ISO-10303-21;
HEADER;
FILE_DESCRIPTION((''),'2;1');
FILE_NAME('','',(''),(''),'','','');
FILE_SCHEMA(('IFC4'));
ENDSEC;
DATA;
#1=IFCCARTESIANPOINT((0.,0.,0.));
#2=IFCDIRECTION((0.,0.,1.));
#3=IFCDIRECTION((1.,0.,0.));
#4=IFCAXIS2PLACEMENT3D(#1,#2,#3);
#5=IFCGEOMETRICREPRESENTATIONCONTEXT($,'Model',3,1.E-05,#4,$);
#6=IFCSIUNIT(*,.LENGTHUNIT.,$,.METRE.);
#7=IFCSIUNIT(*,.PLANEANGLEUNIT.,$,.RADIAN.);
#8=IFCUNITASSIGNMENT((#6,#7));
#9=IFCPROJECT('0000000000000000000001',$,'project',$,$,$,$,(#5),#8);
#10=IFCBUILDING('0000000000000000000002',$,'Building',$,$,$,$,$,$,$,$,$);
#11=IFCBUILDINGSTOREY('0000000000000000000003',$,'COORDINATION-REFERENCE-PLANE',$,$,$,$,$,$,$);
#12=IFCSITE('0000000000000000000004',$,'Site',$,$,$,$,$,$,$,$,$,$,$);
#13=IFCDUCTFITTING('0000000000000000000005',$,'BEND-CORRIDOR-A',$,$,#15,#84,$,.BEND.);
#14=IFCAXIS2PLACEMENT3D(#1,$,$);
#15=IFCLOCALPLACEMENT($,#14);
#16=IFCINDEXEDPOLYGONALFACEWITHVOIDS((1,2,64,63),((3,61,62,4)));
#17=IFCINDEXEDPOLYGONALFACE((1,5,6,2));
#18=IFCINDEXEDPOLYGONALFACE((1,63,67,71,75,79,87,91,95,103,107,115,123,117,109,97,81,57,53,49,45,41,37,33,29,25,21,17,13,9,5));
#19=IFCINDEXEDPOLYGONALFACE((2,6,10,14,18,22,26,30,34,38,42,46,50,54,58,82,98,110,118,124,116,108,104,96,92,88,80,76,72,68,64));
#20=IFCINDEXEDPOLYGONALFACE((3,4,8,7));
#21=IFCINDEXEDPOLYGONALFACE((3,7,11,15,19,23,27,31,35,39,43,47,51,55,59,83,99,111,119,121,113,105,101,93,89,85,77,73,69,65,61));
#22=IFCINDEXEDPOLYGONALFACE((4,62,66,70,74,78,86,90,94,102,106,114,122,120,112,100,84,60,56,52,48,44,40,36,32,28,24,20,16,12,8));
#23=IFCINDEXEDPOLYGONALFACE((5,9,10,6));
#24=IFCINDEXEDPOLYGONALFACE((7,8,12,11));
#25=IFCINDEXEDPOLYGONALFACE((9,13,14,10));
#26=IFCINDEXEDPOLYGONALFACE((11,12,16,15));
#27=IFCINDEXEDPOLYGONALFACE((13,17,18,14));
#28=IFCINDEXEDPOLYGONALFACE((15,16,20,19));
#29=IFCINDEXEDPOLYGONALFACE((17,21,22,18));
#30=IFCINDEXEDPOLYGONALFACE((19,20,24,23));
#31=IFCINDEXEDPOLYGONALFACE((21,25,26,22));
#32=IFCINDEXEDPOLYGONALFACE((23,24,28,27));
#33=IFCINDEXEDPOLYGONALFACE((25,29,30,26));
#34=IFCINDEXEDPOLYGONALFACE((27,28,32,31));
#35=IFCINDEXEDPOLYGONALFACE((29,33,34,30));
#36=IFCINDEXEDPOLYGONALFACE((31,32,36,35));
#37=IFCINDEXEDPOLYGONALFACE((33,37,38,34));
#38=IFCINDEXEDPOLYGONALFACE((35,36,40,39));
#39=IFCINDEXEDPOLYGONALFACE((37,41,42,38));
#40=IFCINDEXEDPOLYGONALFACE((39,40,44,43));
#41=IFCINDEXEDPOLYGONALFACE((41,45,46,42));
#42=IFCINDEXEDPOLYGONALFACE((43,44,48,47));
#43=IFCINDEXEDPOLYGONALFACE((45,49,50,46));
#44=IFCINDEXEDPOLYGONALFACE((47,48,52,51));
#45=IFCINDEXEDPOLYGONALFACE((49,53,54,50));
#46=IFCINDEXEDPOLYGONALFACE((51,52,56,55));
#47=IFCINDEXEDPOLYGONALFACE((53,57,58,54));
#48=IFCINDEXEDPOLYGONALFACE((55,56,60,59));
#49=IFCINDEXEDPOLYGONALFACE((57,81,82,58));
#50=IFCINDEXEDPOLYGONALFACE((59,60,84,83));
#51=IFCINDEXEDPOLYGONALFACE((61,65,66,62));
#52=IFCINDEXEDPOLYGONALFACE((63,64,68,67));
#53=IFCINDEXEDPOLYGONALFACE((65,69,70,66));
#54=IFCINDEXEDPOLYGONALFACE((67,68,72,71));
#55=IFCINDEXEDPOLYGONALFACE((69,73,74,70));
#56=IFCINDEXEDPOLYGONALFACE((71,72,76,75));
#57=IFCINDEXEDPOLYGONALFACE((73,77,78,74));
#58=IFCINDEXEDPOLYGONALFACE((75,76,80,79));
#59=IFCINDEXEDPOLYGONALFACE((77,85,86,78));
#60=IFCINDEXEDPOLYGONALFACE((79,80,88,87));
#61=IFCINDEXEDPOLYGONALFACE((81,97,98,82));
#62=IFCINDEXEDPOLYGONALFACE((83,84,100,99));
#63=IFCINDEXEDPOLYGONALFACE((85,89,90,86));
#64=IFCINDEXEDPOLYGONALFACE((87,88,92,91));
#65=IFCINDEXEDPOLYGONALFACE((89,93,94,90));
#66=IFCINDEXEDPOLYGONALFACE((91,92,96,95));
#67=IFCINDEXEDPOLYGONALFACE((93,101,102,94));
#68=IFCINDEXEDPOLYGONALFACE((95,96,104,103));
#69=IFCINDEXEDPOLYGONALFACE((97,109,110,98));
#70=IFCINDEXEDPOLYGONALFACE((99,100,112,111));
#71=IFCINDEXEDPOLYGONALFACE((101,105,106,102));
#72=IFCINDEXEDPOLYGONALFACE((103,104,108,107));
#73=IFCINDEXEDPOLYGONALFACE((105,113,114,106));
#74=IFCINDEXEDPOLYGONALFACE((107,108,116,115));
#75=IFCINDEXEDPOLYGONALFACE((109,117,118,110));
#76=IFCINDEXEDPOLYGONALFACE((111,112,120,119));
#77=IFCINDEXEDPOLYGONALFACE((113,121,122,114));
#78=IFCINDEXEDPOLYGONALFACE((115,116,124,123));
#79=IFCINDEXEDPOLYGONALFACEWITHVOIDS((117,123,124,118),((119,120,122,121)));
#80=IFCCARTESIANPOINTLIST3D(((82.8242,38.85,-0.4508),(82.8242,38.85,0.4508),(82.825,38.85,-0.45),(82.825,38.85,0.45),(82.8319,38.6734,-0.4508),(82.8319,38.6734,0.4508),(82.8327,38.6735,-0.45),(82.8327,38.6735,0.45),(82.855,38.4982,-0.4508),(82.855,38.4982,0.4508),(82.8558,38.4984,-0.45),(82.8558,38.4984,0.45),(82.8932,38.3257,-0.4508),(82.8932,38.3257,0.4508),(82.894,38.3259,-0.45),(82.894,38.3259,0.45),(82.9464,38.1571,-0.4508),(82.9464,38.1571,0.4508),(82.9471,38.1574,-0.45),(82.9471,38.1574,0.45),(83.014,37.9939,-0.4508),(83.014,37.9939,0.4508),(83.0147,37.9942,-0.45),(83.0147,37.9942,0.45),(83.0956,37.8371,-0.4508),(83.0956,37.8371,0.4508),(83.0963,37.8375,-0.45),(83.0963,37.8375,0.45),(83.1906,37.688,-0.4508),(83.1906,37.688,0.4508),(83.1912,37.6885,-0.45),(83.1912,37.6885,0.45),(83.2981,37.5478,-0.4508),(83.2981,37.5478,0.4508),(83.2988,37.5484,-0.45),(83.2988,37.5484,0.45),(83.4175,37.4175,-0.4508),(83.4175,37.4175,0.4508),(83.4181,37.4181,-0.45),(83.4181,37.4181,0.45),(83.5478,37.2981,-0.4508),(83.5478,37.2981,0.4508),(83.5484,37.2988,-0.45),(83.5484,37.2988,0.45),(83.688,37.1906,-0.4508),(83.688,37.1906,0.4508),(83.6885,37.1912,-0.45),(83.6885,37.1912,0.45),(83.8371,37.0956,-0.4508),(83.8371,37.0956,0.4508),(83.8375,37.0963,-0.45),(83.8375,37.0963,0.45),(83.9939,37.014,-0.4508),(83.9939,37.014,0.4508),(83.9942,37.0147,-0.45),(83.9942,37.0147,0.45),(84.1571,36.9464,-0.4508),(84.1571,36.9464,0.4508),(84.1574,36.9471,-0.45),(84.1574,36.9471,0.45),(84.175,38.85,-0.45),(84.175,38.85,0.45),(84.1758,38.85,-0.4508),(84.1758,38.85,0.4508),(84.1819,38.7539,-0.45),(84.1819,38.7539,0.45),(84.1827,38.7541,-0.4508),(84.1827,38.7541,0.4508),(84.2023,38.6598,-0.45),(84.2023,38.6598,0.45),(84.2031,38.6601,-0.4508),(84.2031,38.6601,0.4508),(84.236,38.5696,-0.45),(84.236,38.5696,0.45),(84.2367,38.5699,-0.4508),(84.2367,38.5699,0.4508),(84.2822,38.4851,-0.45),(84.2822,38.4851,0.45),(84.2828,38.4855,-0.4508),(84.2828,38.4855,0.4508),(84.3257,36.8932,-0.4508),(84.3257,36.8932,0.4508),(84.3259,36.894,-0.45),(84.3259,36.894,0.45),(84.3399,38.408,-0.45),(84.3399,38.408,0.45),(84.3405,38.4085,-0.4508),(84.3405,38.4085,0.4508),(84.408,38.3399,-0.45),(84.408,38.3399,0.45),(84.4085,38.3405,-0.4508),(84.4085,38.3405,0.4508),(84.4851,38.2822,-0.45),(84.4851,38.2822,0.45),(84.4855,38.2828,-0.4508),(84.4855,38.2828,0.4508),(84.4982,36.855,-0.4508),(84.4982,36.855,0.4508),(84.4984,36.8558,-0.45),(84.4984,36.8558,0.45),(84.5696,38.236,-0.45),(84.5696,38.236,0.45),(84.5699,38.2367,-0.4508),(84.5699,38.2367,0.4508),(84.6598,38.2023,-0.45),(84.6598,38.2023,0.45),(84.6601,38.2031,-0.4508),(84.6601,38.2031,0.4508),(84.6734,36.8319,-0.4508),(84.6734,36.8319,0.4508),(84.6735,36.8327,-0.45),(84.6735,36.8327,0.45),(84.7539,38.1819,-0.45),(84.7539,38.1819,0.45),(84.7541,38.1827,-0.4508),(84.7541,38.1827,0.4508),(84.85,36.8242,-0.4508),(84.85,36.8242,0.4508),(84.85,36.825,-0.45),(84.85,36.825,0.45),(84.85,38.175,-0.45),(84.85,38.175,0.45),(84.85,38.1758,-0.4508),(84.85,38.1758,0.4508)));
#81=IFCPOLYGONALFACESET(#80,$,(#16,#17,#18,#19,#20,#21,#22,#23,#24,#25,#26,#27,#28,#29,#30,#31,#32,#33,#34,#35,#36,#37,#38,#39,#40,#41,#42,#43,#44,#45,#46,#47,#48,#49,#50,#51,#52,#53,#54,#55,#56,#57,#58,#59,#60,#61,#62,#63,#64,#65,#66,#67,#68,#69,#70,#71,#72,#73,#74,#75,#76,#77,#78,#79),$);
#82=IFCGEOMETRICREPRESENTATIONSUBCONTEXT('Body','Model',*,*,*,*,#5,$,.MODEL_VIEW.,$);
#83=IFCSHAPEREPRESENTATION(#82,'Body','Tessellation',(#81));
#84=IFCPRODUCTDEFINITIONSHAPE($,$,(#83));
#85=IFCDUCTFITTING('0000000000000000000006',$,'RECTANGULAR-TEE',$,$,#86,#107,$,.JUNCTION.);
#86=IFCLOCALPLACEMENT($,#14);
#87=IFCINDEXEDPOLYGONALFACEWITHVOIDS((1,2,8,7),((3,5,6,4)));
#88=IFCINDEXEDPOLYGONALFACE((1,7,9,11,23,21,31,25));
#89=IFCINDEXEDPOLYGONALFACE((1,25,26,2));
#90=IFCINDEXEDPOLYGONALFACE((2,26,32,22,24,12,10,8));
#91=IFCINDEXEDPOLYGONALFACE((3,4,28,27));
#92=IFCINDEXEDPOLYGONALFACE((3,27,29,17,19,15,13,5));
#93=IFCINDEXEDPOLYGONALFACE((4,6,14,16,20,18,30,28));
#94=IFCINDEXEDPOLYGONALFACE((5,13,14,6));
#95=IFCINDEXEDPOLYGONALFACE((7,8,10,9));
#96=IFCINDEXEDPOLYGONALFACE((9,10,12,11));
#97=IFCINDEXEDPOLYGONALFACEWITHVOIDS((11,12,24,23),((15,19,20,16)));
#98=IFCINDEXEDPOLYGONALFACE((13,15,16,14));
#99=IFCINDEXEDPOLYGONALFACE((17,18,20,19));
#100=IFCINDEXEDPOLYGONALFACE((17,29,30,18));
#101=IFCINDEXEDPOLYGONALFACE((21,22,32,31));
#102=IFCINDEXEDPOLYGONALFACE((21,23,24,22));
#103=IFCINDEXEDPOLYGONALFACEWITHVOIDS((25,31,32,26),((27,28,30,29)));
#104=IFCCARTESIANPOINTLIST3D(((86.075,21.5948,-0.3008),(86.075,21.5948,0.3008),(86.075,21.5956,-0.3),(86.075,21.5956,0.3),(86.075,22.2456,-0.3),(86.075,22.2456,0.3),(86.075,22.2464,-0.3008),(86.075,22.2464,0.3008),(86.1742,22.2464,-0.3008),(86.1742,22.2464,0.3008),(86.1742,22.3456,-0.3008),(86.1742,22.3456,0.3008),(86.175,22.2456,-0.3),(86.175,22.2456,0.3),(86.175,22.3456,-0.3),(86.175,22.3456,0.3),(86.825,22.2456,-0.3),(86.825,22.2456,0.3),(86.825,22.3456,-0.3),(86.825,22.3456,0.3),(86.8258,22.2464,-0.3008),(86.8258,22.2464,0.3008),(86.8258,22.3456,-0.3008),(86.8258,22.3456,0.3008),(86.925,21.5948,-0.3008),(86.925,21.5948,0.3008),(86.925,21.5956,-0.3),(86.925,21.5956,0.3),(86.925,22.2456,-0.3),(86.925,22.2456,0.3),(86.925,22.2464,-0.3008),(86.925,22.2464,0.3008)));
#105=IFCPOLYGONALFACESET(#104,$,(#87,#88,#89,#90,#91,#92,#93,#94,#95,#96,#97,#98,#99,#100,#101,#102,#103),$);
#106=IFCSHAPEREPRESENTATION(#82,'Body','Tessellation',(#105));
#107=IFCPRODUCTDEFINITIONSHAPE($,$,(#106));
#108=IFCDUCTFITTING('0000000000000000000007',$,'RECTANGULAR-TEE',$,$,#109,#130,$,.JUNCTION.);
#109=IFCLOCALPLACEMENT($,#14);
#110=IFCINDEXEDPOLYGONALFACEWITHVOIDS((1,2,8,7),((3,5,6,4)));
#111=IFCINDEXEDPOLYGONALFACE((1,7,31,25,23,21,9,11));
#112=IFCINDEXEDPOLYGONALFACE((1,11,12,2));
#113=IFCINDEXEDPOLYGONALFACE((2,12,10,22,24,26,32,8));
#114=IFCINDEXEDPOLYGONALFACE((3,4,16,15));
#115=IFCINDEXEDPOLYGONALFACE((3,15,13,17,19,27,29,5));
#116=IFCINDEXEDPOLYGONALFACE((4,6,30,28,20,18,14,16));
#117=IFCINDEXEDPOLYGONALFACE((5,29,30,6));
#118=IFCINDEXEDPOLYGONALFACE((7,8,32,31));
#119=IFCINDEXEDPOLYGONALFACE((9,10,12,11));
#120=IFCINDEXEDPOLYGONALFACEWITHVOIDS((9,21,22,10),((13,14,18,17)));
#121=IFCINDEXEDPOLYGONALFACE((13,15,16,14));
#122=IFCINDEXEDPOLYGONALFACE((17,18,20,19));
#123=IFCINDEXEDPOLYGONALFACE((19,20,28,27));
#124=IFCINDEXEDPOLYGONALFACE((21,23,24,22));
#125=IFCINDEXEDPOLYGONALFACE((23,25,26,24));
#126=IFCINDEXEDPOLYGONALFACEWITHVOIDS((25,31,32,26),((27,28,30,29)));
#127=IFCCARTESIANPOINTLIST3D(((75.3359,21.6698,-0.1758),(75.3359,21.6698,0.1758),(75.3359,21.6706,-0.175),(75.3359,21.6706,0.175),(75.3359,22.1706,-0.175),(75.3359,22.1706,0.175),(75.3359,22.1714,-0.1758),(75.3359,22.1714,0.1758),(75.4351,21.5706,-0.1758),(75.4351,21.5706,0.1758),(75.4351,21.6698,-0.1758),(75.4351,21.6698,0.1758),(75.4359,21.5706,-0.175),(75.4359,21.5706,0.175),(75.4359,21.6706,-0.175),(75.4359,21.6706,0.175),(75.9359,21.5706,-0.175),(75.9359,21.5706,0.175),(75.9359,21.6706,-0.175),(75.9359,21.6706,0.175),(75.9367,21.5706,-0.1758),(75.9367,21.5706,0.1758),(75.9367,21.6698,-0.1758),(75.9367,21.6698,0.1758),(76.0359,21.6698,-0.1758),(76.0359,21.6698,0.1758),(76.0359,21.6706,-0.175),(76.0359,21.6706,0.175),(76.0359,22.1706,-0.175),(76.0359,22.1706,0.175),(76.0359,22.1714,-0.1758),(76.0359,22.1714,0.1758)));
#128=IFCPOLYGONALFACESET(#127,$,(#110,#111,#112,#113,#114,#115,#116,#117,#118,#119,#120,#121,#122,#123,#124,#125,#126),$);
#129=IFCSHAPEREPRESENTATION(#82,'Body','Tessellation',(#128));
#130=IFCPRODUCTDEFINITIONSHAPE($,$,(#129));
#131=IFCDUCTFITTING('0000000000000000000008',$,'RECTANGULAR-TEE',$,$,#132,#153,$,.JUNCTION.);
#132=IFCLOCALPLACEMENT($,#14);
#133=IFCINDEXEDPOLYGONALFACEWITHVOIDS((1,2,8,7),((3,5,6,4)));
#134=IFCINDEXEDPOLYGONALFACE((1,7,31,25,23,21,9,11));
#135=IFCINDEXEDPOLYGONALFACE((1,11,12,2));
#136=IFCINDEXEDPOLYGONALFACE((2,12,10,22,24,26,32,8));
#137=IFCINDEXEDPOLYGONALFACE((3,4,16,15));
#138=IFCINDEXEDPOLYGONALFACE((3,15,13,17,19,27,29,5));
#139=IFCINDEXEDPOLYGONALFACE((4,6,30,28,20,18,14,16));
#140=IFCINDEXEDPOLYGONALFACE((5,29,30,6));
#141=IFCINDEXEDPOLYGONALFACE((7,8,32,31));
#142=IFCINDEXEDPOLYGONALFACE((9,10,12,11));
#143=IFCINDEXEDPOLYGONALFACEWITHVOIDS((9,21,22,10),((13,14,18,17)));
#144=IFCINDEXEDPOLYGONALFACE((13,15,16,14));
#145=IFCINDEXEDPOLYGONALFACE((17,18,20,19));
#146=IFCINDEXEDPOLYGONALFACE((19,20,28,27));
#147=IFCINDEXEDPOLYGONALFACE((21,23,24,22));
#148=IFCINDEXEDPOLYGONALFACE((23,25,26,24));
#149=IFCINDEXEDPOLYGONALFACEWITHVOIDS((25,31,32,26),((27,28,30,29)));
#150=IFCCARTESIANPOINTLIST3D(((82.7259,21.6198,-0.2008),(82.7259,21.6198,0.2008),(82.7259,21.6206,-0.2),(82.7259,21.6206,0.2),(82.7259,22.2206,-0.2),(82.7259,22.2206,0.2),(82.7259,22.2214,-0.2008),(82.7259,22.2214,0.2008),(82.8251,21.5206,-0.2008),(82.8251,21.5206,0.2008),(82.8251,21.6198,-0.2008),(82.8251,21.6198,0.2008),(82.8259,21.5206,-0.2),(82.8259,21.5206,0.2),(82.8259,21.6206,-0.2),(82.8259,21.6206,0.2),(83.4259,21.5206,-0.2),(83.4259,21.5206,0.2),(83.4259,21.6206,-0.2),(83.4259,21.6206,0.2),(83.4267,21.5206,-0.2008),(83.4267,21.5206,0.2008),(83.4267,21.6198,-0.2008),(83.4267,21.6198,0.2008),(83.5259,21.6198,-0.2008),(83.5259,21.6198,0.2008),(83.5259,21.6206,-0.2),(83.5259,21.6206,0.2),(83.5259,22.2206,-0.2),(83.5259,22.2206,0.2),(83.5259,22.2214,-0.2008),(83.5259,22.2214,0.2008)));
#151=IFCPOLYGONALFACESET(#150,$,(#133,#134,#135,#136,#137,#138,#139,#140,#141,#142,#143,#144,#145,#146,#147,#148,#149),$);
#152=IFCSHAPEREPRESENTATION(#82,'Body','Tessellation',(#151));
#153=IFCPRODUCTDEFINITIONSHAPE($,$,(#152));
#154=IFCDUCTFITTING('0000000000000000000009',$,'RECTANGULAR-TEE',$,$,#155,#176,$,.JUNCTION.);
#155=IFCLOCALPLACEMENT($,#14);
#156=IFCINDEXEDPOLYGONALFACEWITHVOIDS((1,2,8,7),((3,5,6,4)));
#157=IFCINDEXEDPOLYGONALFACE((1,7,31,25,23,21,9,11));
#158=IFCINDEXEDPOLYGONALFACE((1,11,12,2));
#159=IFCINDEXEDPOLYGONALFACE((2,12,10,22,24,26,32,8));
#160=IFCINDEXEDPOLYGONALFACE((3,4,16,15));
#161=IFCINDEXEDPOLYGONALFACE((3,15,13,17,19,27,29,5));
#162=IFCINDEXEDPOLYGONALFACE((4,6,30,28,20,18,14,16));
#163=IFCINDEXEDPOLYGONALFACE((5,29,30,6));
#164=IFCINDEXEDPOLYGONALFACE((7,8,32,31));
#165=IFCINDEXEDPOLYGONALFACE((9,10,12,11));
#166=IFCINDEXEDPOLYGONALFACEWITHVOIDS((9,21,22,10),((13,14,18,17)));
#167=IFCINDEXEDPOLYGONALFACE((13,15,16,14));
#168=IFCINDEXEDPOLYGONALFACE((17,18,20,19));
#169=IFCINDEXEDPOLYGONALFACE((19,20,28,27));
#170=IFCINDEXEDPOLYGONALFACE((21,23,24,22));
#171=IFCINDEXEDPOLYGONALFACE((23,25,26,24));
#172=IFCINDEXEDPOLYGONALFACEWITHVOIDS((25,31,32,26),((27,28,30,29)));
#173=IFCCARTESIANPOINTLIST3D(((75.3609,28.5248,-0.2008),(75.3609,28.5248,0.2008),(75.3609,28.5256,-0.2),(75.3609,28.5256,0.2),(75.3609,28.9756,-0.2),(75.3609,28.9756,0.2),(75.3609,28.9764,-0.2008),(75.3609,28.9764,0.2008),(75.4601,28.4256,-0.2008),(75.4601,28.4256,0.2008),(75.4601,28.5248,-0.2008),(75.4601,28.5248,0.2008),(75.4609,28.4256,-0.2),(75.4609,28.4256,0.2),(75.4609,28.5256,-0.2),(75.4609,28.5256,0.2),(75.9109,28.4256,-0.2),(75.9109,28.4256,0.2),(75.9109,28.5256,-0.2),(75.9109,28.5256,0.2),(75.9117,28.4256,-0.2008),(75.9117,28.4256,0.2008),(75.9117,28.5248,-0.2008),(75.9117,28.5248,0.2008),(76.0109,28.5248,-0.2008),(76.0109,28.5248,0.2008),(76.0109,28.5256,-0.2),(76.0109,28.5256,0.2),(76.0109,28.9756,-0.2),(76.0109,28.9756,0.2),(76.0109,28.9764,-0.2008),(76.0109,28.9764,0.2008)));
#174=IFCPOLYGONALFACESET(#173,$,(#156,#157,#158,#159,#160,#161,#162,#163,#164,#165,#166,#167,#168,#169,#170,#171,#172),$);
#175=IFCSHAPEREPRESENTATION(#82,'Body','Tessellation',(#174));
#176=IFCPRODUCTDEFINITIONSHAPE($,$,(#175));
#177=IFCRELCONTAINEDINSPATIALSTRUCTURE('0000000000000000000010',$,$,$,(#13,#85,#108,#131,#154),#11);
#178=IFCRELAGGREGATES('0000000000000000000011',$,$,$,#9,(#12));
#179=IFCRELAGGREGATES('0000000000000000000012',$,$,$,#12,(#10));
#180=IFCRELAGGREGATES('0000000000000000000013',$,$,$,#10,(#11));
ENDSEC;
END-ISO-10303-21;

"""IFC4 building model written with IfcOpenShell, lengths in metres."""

from ifc_helpers import new_model, entity, si_unit, frame, origin_with_axes, place, context, subcontext, project, spatial, rectangle, extrude, boolean, element, save


model = new_model("IFC4")

# Units and contexts
model_context = context("Model", 3, precision=1e-05, world=origin_with_axes())
body_context = subcontext(model_context, "Body", "Model", "MODEL_VIEW")
ifc_project = project(units=[si_unit("LENGTHUNIT", "METRE"), si_unit("PLANEANGLEUNIT", "RADIAN")], contexts=[model_context])

# Site, building, storey
site = spatial("IfcSite", under=ifc_project, Name="Site")
building = spatial("IfcBuilding", under=site, Name="Building")
storey = spatial("IfcBuildingStorey", under=building, Name="COORDINATION-REFERENCE-PLANE")

# Duct fittings
duct_fitting_1_placement = place(None, frame((84.85, 38.85, 0.0), z_axis=(0.0, 0.0, 1.0), x_axis=(-1.0, 0.0, 0.0)))
cartesian_point_1 = entity("IfcCartesianPoint", [0.0, 0.0, 0.0])
element("IfcDuctFitting", 1, at=duct_fitting_1_placement, inside=storey, Name="BEND-CORRIDOR-A", PredefinedType="BEND", context=body_context, shape_type="SweptSolid", body=[
    entity("IfcRevolvedAreaSolid", entity("IfcRectangleHollowProfileDef", "AREA", None, entity("IfcAxis2Placement2D", entity("IfcCartesianPoint", [1.35, 0.0])), 1.3516, 0.9016, 0.0008), entity("IfcAxis2Placement3D", cartesian_point_1, entity("IfcDirection", [0.0, -1.0, 0.0]), entity("IfcDirection", [1.0, 0.0, 0.0])), entity("IfcAxis1Placement", cartesian_point_1, entity("IfcDirection", [0.0, 1.0, 0.0])), 1.570796),
])
duct_fitting_2_placement = place(None, frame((86.5, 21.9206, 0.0), z_axis=(1.0, 0.0, 0.0), x_axis=(0.0, 1.0, 0.0)))
solid_1 = boolean("UNION", extrude(rectangle(XDim=0.65, YDim=0.6), frame((0.0, 0.0, -0.425), z_axis=(0.0, 0.0, 1.0), x_axis=(1.0, 0.0, 0.0)), (0.0, 0.0, 1.0), 0.85), extrude(rectangle(XDim=0.65, YDim=0.6), frame((0.0, 0.0, 0.0), z_axis=(1.0, 0.0, 0.0), x_axis=(0.0, 0.0, -1.0)), (0.0, 0.0, 1.0), 0.425))
element("IfcDuctFitting", 2, at=duct_fitting_2_placement, inside=storey, Name="RECTANGULAR-TEE", PredefinedType="JUNCTION", context=body_context, shape_type="CSG", body=[
    boolean("DIFFERENCE", boolean("UNION", extrude(rectangle(XDim=0.6516, YDim=0.6016), frame((0.0, 0.0, -0.425), z_axis=(0.0, 0.0, 1.0), x_axis=(1.0, 0.0, 0.0)), (0.0, 0.0, 1.0), 0.85), extrude(rectangle(XDim=0.6516, YDim=0.6016), frame((0.0, 0.0, 0.0), z_axis=(1.0, 0.0, 0.0), x_axis=(0.0, 0.0, -1.0)), (0.0, 0.0, 1.0), 0.425)), solid_1),
])
duct_fitting_3_placement = place(None, frame((75.6859, 21.9206, 0.0), z_axis=(-1.0, 0.0, 0.0), x_axis=(0.0, -1.0, 0.0)))
solid_2 = boolean("UNION", extrude(rectangle(XDim=0.5, YDim=0.35), frame((0.0, 0.0, -0.35), z_axis=(0.0, 0.0, 1.0), x_axis=(1.0, 0.0, 0.0)), (0.0, 0.0, 1.0), 0.7), extrude(rectangle(XDim=0.5, YDim=0.35), frame((0.0, 0.0, 0.0), z_axis=(1.0, 0.0, 0.0), x_axis=(0.0, 0.0, -1.0)), (0.0, 0.0, 1.0), 0.35))
element("IfcDuctFitting", 3, at=duct_fitting_3_placement, inside=storey, Name="RECTANGULAR-TEE", PredefinedType="JUNCTION", context=body_context, shape_type="CSG", body=[
    boolean("DIFFERENCE", boolean("UNION", extrude(rectangle(XDim=0.5016, YDim=0.3516), frame((0.0, 0.0, -0.35), z_axis=(0.0, 0.0, 1.0), x_axis=(1.0, 0.0, 0.0)), (0.0, 0.0, 1.0), 0.7), extrude(rectangle(XDim=0.5016, YDim=0.3516), frame((0.0, 0.0, 0.0), z_axis=(1.0, 0.0, 0.0), x_axis=(0.0, 0.0, -1.0)), (0.0, 0.0, 1.0), 0.35)), solid_2),
])
duct_fitting_4_placement = place(None, frame((83.1259, 21.9206, 0.0), z_axis=(-1.0, 0.0, 0.0), x_axis=(0.0, -1.0, 0.0)))
solid_3 = boolean("UNION", extrude(rectangle(XDim=0.6, YDim=0.4), frame((0.0, 0.0, -0.4), z_axis=(0.0, 0.0, 1.0), x_axis=(1.0, 0.0, 0.0)), (0.0, 0.0, 1.0), 0.8), extrude(rectangle(XDim=0.6, YDim=0.4), frame((0.0, 0.0, 0.0), z_axis=(1.0, 0.0, 0.0), x_axis=(0.0, 0.0, -1.0)), (0.0, 0.0, 1.0), 0.4))
element("IfcDuctFitting", 4, at=duct_fitting_4_placement, inside=storey, Name="RECTANGULAR-TEE", PredefinedType="JUNCTION", context=body_context, shape_type="CSG", body=[
    boolean("DIFFERENCE", boolean("UNION", extrude(rectangle(XDim=0.6016, YDim=0.4016), frame((0.0, 0.0, -0.4), z_axis=(0.0, 0.0, 1.0), x_axis=(1.0, 0.0, 0.0)), (0.0, 0.0, 1.0), 0.8), extrude(rectangle(XDim=0.6016, YDim=0.4016), frame((0.0, 0.0, 0.0), z_axis=(1.0, 0.0, 0.0), x_axis=(0.0, 0.0, -1.0)), (0.0, 0.0, 1.0), 0.4)), solid_3),
])
duct_fitting_5_placement = place(None, frame((75.6859, 28.7506, 0.0), z_axis=(-1.0, 0.0, 0.0), x_axis=(0.0, -1.0, 0.0)))
solid_4 = boolean("UNION", extrude(rectangle(XDim=0.45, YDim=0.4), frame((0.0, 0.0, -0.325), z_axis=(0.0, 0.0, 1.0), x_axis=(1.0, 0.0, 0.0)), (0.0, 0.0, 1.0), 0.65), extrude(rectangle(XDim=0.45, YDim=0.4), frame((0.0, 0.0, 0.0), z_axis=(1.0, 0.0, 0.0), x_axis=(0.0, 0.0, -1.0)), (0.0, 0.0, 1.0), 0.325))
element("IfcDuctFitting", 5, at=duct_fitting_5_placement, inside=storey, Name="RECTANGULAR-TEE", PredefinedType="JUNCTION", context=body_context, shape_type="CSG", body=[
    boolean("DIFFERENCE", boolean("UNION", extrude(rectangle(XDim=0.4516, YDim=0.4016), frame((0.0, 0.0, -0.325), z_axis=(0.0, 0.0, 1.0), x_axis=(1.0, 0.0, 0.0)), (0.0, 0.0, 1.0), 0.65), extrude(rectangle(XDim=0.4516, YDim=0.4016), frame((0.0, 0.0, 0.0), z_axis=(1.0, 0.0, 0.0), x_axis=(0.0, 0.0, -1.0)), (0.0, 0.0, 1.0), 0.325)), solid_4),
])

save(model, "model.ifc")
